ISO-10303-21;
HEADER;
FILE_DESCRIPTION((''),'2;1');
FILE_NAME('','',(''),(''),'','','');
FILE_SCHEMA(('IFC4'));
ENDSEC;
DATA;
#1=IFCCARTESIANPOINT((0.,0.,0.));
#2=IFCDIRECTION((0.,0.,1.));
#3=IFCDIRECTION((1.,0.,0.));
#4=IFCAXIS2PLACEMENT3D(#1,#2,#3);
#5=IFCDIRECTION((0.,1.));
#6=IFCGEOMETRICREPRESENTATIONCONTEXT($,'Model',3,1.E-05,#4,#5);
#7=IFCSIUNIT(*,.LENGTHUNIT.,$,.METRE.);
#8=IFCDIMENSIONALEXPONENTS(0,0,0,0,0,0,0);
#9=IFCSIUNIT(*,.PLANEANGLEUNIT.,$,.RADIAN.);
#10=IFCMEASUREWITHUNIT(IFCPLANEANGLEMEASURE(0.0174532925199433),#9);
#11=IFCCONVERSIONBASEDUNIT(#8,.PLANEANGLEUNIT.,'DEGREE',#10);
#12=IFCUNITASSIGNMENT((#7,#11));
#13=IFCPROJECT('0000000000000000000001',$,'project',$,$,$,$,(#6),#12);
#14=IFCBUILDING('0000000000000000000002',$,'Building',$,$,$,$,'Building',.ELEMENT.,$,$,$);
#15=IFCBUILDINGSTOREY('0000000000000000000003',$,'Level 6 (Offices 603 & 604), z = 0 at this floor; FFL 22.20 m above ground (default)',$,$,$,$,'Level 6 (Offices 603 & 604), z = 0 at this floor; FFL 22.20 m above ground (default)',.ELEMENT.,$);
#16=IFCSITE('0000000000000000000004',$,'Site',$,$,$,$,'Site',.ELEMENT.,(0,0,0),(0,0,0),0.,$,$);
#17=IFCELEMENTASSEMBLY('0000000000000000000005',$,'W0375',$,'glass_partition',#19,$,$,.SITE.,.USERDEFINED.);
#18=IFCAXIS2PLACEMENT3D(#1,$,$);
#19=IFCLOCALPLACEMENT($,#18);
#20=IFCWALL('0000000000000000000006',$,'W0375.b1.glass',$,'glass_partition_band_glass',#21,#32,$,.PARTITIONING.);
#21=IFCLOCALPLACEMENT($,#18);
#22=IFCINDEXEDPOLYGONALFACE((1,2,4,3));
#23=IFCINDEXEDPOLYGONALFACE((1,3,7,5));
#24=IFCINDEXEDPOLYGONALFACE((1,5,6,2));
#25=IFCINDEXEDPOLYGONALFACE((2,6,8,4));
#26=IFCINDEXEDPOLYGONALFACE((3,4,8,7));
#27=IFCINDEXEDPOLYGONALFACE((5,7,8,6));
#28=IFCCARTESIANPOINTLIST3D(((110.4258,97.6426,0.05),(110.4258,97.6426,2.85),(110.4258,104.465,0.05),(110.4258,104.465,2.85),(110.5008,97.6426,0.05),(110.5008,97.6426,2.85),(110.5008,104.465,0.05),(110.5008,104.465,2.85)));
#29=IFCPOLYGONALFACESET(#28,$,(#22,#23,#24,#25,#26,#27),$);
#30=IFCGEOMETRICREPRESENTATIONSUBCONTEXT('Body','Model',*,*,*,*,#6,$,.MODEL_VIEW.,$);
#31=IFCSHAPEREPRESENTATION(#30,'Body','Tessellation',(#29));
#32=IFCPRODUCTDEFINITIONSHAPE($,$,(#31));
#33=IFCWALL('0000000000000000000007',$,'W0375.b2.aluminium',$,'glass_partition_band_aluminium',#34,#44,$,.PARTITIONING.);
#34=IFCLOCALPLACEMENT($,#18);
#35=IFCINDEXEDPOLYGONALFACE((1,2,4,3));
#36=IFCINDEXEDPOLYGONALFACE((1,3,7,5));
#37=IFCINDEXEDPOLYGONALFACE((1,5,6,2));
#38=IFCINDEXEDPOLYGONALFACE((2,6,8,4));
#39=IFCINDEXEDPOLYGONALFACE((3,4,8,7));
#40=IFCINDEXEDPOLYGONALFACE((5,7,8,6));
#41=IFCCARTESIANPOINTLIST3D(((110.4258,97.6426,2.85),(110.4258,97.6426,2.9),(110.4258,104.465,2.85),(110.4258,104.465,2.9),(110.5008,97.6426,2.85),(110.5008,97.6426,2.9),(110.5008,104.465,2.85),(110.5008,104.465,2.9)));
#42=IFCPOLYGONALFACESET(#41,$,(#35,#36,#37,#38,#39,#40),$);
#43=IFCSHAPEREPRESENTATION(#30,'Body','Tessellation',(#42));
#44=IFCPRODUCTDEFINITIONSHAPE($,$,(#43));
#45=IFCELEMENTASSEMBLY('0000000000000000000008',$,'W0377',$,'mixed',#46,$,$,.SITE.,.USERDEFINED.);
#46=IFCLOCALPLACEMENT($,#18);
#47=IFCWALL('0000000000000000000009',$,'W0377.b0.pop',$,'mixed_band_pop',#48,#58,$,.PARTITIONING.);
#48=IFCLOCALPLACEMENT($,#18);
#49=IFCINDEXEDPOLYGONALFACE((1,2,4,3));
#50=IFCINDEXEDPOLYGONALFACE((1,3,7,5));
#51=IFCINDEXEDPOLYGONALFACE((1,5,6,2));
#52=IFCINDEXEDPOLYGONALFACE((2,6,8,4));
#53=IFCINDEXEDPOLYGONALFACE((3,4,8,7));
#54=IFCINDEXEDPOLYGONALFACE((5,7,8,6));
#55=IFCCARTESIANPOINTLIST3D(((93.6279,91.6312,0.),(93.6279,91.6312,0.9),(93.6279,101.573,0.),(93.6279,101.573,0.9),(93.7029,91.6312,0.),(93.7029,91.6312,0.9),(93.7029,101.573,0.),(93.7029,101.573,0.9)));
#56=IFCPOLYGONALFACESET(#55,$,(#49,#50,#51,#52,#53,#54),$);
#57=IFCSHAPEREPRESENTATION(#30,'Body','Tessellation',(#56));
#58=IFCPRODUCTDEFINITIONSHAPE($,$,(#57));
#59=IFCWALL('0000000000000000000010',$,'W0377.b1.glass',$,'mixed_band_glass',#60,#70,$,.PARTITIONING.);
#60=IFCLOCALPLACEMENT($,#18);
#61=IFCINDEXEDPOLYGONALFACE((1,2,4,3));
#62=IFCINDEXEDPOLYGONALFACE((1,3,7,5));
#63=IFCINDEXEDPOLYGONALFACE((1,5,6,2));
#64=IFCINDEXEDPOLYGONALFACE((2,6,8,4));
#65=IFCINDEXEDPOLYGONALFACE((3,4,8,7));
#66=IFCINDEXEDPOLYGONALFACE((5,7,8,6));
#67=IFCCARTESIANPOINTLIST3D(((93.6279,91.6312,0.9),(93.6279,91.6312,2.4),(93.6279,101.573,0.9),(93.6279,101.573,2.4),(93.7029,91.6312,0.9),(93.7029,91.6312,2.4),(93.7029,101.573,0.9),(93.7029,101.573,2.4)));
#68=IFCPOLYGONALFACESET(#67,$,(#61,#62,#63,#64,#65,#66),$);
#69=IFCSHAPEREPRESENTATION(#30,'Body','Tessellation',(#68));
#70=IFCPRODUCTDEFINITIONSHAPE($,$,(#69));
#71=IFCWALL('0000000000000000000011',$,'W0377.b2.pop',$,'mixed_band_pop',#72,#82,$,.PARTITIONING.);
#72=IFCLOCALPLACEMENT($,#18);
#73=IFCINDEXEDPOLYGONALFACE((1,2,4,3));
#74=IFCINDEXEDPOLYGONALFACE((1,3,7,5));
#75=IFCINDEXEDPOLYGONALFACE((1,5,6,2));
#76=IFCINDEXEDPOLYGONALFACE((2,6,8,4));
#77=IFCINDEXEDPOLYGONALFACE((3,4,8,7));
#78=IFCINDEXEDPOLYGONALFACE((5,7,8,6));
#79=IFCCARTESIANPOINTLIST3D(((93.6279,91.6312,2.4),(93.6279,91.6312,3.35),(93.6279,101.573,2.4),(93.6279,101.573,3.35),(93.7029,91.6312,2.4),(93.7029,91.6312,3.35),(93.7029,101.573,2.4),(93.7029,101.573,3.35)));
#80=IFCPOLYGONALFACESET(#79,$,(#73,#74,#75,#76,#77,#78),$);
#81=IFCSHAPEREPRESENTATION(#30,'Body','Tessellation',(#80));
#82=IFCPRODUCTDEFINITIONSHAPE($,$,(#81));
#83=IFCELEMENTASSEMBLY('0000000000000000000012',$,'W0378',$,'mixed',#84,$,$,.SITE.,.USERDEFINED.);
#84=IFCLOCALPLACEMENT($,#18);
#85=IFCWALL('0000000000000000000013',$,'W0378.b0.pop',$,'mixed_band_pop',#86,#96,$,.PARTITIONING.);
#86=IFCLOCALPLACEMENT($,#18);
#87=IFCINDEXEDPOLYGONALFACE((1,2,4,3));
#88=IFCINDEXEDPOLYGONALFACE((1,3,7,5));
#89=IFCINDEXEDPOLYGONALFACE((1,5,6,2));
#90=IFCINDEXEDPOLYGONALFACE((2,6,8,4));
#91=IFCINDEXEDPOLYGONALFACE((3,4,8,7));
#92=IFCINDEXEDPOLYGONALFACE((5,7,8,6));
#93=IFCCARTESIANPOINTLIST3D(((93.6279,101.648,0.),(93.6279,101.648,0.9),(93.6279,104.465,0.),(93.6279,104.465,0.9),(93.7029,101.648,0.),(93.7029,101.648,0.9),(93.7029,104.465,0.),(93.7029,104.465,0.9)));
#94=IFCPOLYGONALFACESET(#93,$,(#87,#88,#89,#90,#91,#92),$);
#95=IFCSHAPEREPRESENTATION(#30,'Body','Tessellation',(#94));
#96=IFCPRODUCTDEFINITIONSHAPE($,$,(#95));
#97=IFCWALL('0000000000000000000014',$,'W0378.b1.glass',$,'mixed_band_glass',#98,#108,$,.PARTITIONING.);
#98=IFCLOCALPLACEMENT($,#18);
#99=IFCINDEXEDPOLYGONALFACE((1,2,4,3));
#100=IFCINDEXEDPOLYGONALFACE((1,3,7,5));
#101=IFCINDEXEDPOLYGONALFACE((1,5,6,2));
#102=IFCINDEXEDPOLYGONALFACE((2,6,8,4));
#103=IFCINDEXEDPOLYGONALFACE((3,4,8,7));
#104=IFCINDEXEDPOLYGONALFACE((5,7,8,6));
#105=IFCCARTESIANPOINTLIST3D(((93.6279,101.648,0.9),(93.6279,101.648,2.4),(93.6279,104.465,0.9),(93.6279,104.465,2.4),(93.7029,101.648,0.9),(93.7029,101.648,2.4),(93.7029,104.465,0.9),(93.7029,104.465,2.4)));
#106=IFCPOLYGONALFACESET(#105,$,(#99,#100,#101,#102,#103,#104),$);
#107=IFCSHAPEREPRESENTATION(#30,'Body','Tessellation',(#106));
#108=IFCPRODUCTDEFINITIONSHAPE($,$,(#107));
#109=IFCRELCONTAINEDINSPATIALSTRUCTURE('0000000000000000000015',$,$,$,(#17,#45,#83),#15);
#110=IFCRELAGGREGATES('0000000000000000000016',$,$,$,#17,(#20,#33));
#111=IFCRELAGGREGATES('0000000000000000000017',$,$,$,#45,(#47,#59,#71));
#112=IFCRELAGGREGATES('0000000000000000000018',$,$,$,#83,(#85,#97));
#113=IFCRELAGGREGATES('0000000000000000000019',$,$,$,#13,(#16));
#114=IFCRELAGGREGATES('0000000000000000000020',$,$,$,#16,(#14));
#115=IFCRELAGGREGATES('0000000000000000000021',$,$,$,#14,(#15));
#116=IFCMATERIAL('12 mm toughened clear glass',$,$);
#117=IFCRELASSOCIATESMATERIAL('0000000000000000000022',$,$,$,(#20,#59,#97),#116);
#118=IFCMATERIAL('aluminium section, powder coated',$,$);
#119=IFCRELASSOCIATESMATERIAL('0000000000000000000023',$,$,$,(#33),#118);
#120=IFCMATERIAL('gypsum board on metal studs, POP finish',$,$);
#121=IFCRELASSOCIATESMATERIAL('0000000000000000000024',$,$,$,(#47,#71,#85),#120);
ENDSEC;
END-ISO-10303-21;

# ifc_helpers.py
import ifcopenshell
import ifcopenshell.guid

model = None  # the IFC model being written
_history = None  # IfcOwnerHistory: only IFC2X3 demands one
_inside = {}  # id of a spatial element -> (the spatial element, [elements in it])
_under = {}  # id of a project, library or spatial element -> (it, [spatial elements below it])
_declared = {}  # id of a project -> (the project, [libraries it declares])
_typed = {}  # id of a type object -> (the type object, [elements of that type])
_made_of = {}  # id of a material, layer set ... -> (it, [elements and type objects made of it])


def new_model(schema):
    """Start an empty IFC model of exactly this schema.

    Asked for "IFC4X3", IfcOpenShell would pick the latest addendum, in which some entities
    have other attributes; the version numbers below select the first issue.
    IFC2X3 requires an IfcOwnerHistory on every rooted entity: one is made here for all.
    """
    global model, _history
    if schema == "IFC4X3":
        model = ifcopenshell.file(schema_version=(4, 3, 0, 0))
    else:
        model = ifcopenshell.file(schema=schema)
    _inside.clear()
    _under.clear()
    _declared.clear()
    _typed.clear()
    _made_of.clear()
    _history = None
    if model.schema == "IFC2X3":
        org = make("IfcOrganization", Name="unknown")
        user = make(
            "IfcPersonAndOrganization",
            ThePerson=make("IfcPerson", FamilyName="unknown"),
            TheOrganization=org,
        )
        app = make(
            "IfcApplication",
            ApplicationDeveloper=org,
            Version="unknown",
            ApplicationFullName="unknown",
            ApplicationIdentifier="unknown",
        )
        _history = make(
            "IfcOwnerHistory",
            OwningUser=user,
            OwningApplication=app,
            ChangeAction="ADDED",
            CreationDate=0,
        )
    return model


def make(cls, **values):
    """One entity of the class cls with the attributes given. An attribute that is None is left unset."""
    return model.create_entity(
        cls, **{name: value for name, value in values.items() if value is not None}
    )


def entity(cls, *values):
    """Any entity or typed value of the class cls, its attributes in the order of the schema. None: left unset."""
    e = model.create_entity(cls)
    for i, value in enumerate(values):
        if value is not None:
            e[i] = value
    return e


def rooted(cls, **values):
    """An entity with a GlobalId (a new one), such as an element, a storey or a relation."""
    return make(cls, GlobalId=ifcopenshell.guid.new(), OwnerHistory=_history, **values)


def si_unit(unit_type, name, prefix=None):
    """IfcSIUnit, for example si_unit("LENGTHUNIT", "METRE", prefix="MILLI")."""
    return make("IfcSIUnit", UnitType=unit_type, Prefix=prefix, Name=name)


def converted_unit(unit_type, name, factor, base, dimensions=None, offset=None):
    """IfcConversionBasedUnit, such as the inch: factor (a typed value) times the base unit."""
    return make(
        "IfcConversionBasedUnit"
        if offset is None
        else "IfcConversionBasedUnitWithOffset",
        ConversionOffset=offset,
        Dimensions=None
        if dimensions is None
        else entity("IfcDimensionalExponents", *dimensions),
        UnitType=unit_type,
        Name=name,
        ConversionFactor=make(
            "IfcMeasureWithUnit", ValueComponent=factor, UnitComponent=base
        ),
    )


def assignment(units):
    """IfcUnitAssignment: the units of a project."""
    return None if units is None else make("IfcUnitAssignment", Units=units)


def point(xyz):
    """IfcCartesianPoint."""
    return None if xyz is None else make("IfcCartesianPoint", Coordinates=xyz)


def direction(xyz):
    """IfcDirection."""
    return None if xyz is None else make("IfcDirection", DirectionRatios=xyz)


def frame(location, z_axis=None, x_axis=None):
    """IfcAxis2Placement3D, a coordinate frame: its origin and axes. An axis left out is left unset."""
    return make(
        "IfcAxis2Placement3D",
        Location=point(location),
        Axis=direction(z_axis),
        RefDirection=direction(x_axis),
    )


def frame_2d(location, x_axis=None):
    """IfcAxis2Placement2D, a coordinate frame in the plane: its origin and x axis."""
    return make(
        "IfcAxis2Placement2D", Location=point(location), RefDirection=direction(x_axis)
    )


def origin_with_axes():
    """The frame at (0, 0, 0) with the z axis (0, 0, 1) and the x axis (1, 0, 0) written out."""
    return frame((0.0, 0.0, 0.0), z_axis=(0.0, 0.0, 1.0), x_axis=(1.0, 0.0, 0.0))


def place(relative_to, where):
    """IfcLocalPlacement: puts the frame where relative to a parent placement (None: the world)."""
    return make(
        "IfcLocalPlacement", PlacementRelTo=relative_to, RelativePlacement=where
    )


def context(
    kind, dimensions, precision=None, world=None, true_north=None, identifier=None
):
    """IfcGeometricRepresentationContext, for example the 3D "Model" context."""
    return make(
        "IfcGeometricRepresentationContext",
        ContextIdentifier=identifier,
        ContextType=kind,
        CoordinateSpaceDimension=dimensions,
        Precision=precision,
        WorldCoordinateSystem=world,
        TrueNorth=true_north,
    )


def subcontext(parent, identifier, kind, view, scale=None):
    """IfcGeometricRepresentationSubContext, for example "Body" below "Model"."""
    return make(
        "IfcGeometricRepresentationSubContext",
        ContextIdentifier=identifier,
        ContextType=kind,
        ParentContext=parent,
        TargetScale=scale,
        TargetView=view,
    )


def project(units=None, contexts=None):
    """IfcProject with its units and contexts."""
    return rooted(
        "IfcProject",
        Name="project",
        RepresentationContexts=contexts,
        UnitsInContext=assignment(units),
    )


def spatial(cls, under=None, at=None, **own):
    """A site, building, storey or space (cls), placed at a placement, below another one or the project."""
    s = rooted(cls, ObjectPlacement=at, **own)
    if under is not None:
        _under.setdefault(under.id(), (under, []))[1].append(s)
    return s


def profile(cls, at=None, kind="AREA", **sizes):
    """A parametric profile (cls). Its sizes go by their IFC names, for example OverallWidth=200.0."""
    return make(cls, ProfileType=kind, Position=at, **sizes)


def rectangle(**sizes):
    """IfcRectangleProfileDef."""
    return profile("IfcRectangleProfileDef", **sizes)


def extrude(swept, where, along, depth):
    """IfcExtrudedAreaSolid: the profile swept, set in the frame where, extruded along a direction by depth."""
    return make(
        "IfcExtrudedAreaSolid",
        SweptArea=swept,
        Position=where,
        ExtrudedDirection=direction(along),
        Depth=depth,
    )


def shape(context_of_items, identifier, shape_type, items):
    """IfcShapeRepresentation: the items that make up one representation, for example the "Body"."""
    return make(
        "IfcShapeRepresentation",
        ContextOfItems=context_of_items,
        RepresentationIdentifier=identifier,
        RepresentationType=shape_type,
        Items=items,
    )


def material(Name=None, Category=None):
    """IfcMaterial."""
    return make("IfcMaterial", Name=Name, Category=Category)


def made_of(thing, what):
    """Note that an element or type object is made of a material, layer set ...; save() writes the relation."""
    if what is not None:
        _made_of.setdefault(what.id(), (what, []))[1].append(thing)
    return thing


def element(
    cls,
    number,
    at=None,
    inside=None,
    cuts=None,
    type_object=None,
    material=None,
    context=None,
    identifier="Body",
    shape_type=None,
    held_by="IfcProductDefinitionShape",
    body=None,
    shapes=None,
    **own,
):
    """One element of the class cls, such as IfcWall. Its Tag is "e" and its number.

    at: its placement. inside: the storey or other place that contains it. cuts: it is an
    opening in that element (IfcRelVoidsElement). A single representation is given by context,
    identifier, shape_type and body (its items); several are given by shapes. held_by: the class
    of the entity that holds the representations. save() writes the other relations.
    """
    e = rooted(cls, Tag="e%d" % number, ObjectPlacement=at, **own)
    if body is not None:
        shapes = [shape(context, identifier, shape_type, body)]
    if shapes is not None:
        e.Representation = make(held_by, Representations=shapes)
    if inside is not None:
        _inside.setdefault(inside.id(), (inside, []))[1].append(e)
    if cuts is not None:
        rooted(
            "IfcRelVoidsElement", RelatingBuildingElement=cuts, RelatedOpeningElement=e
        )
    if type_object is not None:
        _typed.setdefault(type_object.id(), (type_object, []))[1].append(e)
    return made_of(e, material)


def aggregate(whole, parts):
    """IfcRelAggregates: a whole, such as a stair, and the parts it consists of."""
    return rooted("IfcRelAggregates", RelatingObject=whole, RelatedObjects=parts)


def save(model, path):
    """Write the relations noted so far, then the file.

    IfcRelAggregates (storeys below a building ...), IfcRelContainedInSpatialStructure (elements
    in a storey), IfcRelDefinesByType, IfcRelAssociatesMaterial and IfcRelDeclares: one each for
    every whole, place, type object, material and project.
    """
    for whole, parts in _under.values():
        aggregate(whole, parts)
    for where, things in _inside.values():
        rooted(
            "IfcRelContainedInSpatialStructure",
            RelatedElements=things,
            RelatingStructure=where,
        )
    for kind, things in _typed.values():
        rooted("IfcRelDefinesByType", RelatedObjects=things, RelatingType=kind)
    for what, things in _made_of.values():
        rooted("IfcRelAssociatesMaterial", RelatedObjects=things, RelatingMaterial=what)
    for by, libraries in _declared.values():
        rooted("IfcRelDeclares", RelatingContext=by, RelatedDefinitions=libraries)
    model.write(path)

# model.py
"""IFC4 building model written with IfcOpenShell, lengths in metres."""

from ifc_helpers import new_model, entity, si_unit, converted_unit, direction, frame, frame_2d, origin_with_axes, place, context, subcontext, project, spatial, rectangle, extrude, material, element, aggregate, save


model = new_model("IFC4")

# Units and contexts
model_context = context("Model", 3, precision=1e-05, world=origin_with_axes(), true_north=direction((0.0, 1.0)))
body_context = subcontext(model_context, "Body", "Model", "MODEL_VIEW")
ifc_project = project(units=[si_unit("LENGTHUNIT", "METRE"), converted_unit("PLANEANGLEUNIT", "DEGREE", entity("IfcPlaneAngleMeasure", 0.0174532925199433), si_unit("PLANEANGLEUNIT", "RADIAN"), dimensions=[0, 0, 0, 0, 0, 0, 0])], contexts=[model_context])

# Site, building, storey
site = spatial("IfcSite", under=ifc_project, Name="Site", LongName="Site", CompositionType="ELEMENT", RefLatitude=(0, 0, 0), RefLongitude=(0, 0, 0), RefElevation=0.0)
building = spatial("IfcBuilding", under=site, Name="Building", LongName="Building", CompositionType="ELEMENT")
storey = spatial("IfcBuildingStorey", under=building, Name="Level 6 (Offices 603 & 604), z = 0 at this floor; FFL 22.20 m above ground (default)", LongName="Level 6 (Offices 603 & 604), z = 0 at this floor; FFL 22.20 m above ground (default)", CompositionType="ELEMENT")

# Shared definitions
ifc_material_1 = material(Name="gypsum board on metal studs, POP finish")
placement = place(None, origin_with_axes())
ifc_material_2 = material(Name="12 mm toughened clear glass")

# Element assemblies, walls
assembly_1 = element("IfcElementAssembly", 1, inside=storey, Name="W0375", ObjectType="glass_partition", AssemblyPlace="SITE", PredefinedType="USERDEFINED")
ifc_material_3 = material(Name="aluminium section, powder coated")
wall_1 = element("IfcWall", 2, at=placement, material=ifc_material_2, Name="W0375.b1.glass", ObjectType="glass_partition_band_glass", PredefinedType="PARTITIONING", context=body_context, shape_type="SweptSolid", body=[
    extrude(rectangle(XDim=6.8224, YDim=0.075, at=frame_2d((0.0, 0.0), x_axis=(0.0, 1.0))), frame((110.4633, 101.0538, 0.05), z_axis=(0.0, 0.0, 1.0), x_axis=(1.0, 0.0, 0.0)), (0.0, 0.0, 1.0), 2.8),
])
wall_2 = element("IfcWall", 3, at=placement, material=ifc_material_3, Name="W0375.b2.aluminium", ObjectType="glass_partition_band_aluminium", PredefinedType="PARTITIONING", context=body_context, shape_type="SweptSolid", body=[
    extrude(rectangle(XDim=6.8224, YDim=0.075, at=frame_2d((0.0, 0.0), x_axis=(0.0, 1.0))), frame((110.4633, 101.0538, 2.85), z_axis=(0.0, 0.0, 1.0), x_axis=(1.0, 0.0, 0.0)), (0.0, 0.0, 1.0), 0.05),
])
aggregate(assembly_1, [wall_1, wall_2])
assembly_2 = element("IfcElementAssembly", 4, inside=storey, Name="W0377", ObjectType="mixed", AssemblyPlace="SITE", PredefinedType="USERDEFINED")
wall_3 = element("IfcWall", 5, at=placement, material=ifc_material_1, Name="W0377.b0.pop", ObjectType="mixed_band_pop", PredefinedType="PARTITIONING", context=body_context, shape_type="SweptSolid", body=[
    extrude(rectangle(XDim=9.9418, YDim=0.075, at=frame_2d((0.0, 0.0), x_axis=(0.0, 1.0))), frame((93.6654, 96.6021, 0.0), z_axis=(0.0, 0.0, 1.0), x_axis=(1.0, 0.0, 0.0)), (0.0, 0.0, 1.0), 0.9),
])
wall_4 = element("IfcWall", 6, at=placement, material=ifc_material_2, Name="W0377.b1.glass", ObjectType="mixed_band_glass", PredefinedType="PARTITIONING", context=body_context, shape_type="SweptSolid", body=[
    extrude(rectangle(XDim=9.9418, YDim=0.075, at=frame_2d((0.0, 0.0), x_axis=(0.0, 1.0))), frame((93.6654, 96.6021, 0.9), z_axis=(0.0, 0.0, 1.0), x_axis=(1.0, 0.0, 0.0)), (0.0, 0.0, 1.0), 1.5),
])
wall_5 = element("IfcWall", 7, at=placement, material=ifc_material_1, Name="W0377.b2.pop", ObjectType="mixed_band_pop", PredefinedType="PARTITIONING", context=body_context, shape_type="SweptSolid", body=[
    extrude(rectangle(XDim=9.9418, YDim=0.075, at=frame_2d((0.0, 0.0), x_axis=(0.0, 1.0))), frame((93.6654, 96.6021, 2.4), z_axis=(0.0, 0.0, 1.0), x_axis=(1.0, 0.0, 0.0)), (0.0, 0.0, 1.0), 0.95),
])
aggregate(assembly_2, [wall_3, wall_4, wall_5])
assembly_3 = element("IfcElementAssembly", 8, inside=storey, Name="W0378", ObjectType="mixed", AssemblyPlace="SITE", PredefinedType="USERDEFINED")
wall_6 = element("IfcWall", 9, at=placement, material=ifc_material_1, Name="W0378.b0.pop", ObjectType="mixed_band_pop", PredefinedType="PARTITIONING", context=body_context, shape_type="SweptSolid", body=[
    extrude(rectangle(XDim=2.817, YDim=0.075, at=frame_2d((0.0, 0.0), x_axis=(0.0, 1.0))), frame((93.6654, 103.0565, 0.0), z_axis=(0.0, 0.0, 1.0), x_axis=(1.0, 0.0, 0.0)), (0.0, 0.0, 1.0), 0.9),
])
wall_7 = element("IfcWall", 10, at=placement, material=ifc_material_2, Name="W0378.b1.glass", ObjectType="mixed_band_glass", PredefinedType="PARTITIONING", context=body_context, shape_type="SweptSolid", body=[
    extrude(rectangle(XDim=2.817, YDim=0.075, at=frame_2d((0.0, 0.0), x_axis=(0.0, 1.0))), frame((93.6654, 103.0565, 0.9), z_axis=(0.0, 0.0, 1.0), x_axis=(1.0, 0.0, 0.0)), (0.0, 0.0, 1.0), 1.5),
])
aggregate(assembly_3, [wall_6, wall_7])

save(model, "model.ifc")
